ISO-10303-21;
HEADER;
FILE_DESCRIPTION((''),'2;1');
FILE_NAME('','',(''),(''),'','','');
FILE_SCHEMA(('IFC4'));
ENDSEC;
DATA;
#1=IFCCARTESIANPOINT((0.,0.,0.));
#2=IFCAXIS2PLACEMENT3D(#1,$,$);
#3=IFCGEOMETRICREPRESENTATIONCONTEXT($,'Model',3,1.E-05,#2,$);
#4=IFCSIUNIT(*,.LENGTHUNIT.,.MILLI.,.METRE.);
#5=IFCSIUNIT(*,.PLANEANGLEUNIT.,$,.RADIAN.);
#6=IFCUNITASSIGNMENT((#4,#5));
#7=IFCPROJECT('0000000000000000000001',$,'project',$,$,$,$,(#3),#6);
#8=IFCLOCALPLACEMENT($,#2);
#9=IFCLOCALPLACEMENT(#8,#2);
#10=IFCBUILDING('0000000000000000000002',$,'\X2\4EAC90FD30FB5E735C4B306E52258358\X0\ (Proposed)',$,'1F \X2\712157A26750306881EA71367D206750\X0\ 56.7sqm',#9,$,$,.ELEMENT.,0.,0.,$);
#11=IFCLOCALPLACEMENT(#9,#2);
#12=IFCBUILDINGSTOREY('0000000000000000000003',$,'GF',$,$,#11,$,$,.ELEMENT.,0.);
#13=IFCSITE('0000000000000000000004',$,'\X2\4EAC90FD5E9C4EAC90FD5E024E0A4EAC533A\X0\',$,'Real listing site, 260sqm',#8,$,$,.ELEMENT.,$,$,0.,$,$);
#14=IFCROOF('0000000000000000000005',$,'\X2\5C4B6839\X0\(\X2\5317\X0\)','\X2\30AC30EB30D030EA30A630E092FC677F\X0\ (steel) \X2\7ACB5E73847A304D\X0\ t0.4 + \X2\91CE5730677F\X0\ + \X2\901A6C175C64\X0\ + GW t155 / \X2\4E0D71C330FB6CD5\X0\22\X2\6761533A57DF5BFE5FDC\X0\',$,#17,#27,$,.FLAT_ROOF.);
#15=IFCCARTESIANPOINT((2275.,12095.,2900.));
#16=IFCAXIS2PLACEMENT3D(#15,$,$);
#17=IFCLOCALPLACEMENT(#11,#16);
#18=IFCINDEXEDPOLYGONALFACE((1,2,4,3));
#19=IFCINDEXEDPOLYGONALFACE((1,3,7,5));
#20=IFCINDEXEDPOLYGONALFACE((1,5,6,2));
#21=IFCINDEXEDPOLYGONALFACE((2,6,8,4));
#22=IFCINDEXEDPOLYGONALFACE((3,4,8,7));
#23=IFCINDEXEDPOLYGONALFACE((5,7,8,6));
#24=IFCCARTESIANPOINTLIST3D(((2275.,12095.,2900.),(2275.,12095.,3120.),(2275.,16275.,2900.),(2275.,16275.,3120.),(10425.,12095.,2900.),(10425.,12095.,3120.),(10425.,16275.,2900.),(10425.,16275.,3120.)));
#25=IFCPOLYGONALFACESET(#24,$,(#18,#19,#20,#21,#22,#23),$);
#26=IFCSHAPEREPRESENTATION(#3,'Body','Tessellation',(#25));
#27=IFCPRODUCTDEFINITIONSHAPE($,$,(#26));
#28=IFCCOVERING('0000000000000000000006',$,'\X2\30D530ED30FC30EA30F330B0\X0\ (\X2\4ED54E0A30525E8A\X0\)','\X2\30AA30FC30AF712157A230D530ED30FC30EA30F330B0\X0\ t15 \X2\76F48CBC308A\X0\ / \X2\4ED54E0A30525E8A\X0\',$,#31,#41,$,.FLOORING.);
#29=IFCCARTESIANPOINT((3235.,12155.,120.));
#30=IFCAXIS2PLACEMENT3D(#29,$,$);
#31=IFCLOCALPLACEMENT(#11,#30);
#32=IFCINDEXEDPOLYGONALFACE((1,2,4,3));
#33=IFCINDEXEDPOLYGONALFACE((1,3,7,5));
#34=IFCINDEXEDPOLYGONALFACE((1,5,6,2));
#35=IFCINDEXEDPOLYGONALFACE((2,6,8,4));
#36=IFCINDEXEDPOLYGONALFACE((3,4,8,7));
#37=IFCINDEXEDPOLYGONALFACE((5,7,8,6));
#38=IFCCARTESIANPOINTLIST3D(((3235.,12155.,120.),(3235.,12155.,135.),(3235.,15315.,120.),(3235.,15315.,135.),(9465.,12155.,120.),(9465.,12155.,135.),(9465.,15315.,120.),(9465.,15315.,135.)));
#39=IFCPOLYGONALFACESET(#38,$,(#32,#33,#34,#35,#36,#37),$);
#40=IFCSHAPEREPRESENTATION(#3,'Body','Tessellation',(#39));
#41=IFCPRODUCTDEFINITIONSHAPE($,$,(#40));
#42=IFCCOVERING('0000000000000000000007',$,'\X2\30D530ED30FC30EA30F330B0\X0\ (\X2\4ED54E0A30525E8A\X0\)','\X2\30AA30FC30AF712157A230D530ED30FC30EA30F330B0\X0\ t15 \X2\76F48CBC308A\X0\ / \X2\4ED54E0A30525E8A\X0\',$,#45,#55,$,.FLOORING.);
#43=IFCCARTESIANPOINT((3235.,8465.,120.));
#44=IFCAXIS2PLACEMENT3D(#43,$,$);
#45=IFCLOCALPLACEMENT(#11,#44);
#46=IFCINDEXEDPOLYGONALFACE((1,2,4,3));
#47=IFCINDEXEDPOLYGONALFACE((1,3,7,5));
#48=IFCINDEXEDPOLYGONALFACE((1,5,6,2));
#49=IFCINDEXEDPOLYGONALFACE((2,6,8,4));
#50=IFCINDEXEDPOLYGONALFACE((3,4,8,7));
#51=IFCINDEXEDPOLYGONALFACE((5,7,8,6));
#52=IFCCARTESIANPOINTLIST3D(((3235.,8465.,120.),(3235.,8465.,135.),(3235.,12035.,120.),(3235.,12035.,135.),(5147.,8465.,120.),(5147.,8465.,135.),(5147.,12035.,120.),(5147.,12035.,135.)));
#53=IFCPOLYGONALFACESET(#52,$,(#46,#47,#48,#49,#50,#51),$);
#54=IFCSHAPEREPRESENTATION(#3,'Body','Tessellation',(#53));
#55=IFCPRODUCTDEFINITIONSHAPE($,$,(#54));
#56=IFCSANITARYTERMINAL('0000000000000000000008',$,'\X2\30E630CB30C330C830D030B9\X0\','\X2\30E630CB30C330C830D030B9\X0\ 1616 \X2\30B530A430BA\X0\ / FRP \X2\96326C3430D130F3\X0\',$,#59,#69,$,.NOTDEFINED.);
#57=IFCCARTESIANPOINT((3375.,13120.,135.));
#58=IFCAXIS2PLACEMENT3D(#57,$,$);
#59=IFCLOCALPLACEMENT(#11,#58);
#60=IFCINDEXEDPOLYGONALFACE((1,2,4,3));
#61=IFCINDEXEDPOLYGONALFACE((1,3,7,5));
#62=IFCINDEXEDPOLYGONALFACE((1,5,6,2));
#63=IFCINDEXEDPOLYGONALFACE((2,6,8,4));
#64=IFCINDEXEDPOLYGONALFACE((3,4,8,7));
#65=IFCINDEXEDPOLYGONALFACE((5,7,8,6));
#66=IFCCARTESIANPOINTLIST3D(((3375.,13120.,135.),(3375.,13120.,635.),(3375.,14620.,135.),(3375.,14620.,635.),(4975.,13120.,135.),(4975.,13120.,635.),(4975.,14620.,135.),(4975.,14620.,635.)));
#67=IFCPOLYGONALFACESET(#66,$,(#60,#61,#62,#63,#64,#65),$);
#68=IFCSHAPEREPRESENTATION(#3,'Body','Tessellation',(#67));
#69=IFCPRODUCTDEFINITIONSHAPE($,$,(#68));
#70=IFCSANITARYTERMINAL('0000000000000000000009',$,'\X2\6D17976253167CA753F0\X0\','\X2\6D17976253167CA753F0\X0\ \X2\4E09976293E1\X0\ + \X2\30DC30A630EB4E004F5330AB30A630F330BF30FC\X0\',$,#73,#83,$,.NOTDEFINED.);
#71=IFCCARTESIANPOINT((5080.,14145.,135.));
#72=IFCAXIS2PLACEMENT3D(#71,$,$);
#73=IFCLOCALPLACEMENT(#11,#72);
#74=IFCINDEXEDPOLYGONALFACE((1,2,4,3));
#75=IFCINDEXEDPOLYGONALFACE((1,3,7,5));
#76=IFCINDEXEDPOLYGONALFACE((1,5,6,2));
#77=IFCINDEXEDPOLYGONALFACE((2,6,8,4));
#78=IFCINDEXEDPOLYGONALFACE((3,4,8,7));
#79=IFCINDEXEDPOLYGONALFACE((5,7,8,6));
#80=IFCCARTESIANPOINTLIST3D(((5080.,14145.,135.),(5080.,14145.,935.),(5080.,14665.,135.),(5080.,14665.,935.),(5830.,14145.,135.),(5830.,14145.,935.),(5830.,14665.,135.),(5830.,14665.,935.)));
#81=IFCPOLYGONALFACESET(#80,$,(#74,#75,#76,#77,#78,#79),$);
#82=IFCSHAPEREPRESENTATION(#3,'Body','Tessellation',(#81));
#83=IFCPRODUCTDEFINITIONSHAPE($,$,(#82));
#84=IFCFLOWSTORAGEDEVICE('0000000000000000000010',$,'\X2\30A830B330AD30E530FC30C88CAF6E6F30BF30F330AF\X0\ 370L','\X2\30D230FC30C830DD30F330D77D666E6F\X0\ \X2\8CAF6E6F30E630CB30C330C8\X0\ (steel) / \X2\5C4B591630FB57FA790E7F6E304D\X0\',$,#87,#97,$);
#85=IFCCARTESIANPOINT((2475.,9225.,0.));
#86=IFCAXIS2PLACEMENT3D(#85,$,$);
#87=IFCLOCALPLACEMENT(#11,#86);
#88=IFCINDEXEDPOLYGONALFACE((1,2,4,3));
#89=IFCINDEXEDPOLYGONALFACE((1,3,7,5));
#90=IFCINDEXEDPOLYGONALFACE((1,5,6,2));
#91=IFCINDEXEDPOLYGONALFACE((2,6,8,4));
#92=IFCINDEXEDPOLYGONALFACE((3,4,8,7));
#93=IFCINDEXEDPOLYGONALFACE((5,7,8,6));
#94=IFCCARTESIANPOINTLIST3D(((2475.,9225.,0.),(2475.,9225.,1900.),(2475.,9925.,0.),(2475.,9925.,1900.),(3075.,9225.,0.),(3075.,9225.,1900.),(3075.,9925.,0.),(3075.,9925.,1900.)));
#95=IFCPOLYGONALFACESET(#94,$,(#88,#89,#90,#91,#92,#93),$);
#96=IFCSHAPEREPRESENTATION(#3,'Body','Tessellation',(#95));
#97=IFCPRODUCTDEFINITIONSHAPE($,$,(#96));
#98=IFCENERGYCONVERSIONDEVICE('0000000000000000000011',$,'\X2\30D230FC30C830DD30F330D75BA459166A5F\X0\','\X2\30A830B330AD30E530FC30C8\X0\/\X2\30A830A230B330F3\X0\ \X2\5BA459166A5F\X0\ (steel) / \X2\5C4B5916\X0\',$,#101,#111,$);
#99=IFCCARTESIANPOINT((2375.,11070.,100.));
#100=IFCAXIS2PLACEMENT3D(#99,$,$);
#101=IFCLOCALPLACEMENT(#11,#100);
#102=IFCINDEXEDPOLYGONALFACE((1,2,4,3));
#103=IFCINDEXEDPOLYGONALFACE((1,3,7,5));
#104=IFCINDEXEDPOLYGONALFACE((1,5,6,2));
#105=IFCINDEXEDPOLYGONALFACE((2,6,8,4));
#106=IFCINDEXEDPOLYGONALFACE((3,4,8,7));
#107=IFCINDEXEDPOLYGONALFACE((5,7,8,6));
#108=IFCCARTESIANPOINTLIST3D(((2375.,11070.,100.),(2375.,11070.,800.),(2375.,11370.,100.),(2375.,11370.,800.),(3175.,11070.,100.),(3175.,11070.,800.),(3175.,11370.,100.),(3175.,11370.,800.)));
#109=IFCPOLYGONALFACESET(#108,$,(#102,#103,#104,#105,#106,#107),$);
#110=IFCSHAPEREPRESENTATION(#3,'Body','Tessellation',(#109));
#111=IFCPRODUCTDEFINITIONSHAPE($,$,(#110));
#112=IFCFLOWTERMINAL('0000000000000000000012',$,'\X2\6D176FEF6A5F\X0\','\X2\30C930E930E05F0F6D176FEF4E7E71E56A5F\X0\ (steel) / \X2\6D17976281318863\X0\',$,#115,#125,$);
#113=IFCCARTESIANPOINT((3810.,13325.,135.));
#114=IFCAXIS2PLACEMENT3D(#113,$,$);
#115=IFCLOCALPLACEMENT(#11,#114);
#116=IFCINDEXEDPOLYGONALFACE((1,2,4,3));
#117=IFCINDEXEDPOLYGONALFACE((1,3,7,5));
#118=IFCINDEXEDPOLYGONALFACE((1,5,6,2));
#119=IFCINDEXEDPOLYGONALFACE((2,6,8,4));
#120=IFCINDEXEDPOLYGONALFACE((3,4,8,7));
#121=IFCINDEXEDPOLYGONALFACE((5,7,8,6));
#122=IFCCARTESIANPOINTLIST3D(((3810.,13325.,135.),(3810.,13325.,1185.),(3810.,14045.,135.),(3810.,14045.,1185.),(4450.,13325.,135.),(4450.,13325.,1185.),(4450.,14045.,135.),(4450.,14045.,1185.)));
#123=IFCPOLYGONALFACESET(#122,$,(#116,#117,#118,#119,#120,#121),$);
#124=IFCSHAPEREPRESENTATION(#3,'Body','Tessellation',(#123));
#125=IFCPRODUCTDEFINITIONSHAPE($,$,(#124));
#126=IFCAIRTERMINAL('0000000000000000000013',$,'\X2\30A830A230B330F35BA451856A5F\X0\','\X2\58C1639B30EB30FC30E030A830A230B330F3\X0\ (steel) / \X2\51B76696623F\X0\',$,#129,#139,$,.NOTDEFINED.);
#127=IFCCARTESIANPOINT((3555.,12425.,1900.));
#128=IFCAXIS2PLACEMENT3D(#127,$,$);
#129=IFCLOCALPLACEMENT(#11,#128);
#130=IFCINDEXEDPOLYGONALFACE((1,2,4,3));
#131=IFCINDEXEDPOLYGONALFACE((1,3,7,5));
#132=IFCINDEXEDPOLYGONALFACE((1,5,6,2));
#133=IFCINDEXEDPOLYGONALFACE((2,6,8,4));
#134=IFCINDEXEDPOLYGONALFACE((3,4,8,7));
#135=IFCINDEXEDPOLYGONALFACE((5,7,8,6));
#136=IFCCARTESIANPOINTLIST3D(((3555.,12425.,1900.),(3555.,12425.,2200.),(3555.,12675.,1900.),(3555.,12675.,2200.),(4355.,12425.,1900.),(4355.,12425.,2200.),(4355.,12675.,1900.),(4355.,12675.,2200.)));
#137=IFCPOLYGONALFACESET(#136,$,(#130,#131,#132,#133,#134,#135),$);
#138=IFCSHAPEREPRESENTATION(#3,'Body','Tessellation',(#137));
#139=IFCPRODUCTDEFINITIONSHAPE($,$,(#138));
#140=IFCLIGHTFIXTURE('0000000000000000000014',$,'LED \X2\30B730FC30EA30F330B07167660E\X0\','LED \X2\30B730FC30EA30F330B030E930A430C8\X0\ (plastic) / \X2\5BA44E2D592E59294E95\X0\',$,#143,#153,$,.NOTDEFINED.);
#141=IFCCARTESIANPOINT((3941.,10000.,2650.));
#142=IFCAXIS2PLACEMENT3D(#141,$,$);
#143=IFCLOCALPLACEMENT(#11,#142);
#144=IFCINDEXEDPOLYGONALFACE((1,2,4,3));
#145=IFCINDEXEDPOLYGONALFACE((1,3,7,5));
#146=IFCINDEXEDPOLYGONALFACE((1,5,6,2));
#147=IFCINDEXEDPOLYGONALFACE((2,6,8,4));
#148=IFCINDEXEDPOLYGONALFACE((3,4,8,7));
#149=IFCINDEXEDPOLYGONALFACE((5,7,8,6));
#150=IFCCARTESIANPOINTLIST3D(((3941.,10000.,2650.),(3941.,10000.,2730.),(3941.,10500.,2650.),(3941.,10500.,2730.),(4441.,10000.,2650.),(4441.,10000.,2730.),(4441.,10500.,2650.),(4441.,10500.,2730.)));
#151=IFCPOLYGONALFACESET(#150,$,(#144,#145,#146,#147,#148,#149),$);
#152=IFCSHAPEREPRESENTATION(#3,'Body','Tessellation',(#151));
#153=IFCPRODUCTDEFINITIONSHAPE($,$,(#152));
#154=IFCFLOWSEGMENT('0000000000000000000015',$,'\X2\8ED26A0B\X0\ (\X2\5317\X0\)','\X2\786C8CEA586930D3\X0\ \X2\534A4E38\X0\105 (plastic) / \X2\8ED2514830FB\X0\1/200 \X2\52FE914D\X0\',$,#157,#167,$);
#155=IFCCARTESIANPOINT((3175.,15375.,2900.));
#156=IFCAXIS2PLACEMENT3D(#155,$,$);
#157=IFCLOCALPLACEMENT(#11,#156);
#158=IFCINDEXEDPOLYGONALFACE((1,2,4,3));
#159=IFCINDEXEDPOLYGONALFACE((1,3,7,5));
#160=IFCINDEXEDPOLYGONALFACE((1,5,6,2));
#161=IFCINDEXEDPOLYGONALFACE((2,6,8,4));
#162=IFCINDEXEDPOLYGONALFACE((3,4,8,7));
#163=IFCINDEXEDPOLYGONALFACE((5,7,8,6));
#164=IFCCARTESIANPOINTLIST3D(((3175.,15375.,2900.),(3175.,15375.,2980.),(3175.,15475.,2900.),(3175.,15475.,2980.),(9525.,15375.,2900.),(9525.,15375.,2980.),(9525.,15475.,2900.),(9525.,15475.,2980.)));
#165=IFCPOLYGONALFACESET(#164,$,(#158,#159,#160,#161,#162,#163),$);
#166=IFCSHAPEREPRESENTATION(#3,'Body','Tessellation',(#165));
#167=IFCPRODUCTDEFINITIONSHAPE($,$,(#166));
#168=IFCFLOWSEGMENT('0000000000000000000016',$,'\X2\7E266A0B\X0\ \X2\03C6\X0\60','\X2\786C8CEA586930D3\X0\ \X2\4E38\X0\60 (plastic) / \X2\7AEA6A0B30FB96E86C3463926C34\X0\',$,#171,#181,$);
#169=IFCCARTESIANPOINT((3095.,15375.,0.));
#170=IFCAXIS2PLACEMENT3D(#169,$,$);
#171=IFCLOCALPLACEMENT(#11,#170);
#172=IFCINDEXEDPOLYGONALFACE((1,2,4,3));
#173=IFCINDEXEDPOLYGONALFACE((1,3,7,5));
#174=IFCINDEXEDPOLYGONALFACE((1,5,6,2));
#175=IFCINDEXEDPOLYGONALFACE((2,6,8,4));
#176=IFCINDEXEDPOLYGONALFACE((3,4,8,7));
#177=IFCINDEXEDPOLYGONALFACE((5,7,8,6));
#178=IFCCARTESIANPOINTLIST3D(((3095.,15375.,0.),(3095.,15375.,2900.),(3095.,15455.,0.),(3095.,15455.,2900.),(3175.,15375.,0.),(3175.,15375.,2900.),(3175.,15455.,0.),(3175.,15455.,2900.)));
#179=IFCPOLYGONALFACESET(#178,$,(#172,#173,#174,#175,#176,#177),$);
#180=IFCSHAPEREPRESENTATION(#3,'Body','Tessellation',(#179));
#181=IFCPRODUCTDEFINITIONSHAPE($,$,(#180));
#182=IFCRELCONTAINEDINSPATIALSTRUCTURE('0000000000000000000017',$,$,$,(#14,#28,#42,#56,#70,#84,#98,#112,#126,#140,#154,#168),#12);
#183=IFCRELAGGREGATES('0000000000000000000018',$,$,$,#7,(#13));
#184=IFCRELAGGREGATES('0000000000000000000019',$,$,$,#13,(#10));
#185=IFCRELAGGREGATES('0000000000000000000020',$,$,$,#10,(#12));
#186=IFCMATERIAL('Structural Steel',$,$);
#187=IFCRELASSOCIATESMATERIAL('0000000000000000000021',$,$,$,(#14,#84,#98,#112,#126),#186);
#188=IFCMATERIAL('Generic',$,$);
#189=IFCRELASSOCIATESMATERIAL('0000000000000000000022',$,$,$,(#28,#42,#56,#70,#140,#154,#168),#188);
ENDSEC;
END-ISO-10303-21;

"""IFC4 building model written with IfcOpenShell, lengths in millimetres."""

from ifc_helpers import new_model, si_unit, frame, frame_2d, origin, place, context, project, spatial, rectangle, extrude, material, element, save


model = new_model("IFC4")

# Units and contexts
model_context = context("Model", 3, precision=1e-05, world=origin())
ifc_project = project(units=[si_unit("LENGTHUNIT", "METRE", prefix="MILLI"), si_unit("PLANEANGLEUNIT", "RADIAN")], contexts=[model_context])

# Site, building, storey
site_placement = place(None, origin())
site = spatial("IfcSite", under=ifc_project, at=site_placement, Name="京都府京都市上京区", ObjectType="Real listing site, 260sqm", CompositionType="ELEMENT", RefElevation=0.0)
building_placement = place(site_placement, origin())
building = spatial("IfcBuilding", under=site, at=building_placement, Name="京都・平屋の別荘 (Proposed)", ObjectType="1F 無垢材と自然素材 56.7sqm", CompositionType="ELEMENT", ElevationOfRefHeight=0.0, ElevationOfTerrain=0.0)
storey_placement = place(building_placement, origin())
storey = spatial("IfcBuildingStorey", under=building, at=storey_placement, Name="GF", CompositionType="ELEMENT", Elevation=0.0)

# Roof
ifc_material_1 = material(Name="Structural Steel")
roof_placement = place(storey_placement, frame((2275.0, 12095.0, 2900.0)))
element("IfcRoof", 1, at=roof_placement, inside=storey, material=ifc_material_1, Name="屋根(北)", Description="ガルバリウム鋼板 (steel) 立平葺き t0.4 + 野地板 + 通気層 + GW t155 / 不燃・法22条区域対応", PredefinedType="FLAT_ROOF", context=model_context, shape_type="SweptSolid", body=[
    extrude(rectangle(XDim=8150.0, YDim=4180.0, at=frame_2d((4075.0, 2090.0))), frame((2275.0, 12095.0, 2900.0)), (0.0, 0.0, 1.0), 220.0),
])

# Coverings
ifc_material_2 = material(Name="Generic")
covering_1_placement = place(storey_placement, frame((3235.0, 12155.0, 120.0)))
element("IfcCovering", 2, at=covering_1_placement, inside=storey, material=ifc_material_2, Name="フローリング (仕上げ床)", Description="オーク無垢フローリング t15 直貼り / 仕上げ床", PredefinedType="FLOORING", context=model_context, shape_type="SweptSolid", body=[
    extrude(rectangle(XDim=6230.0, YDim=3160.0, at=frame_2d((3115.0, 1580.0))), frame((3235.0, 12155.0, 120.0)), (0.0, 0.0, 1.0), 15.0),
])
covering_2_placement = place(storey_placement, frame((3235.0, 8465.0, 120.0)))
element("IfcCovering", 3, at=covering_2_placement, inside=storey, material=ifc_material_2, Name="フローリング (仕上げ床)", Description="オーク無垢フローリング t15 直貼り / 仕上げ床", PredefinedType="FLOORING", context=model_context, shape_type="SweptSolid", body=[
    extrude(rectangle(XDim=1912.0, YDim=3570.0, at=frame_2d((956.0, 1785.0))), frame((3235.0, 8465.0, 120.0)), (0.0, 0.0, 1.0), 15.0),
])

# Sanitary terminals
sanitary_terminal_1_placement = place(storey_placement, frame((3375.0, 13120.0, 135.0)))
element("IfcSanitaryTerminal", 4, at=sanitary_terminal_1_placement, inside=storey, material=ifc_material_2, Name="ユニットバス", Description="ユニットバス 1616 サイズ / FRP 防水パン", PredefinedType="NOTDEFINED", context=model_context, shape_type="SweptSolid", body=[
    extrude(rectangle(XDim=1600.0, YDim=1500.0, at=frame_2d((800.0, 750.0))), frame((3375.0, 13120.0, 135.0)), (0.0, 0.0, 1.0), 500.0),
])
sanitary_terminal_2_placement = place(storey_placement, frame((5080.0, 14145.0, 135.0)))
element("IfcSanitaryTerminal", 5, at=sanitary_terminal_2_placement, inside=storey, material=ifc_material_2, Name="洗面化粧台", Description="洗面化粧台 三面鏡 + ボウル一体カウンター", PredefinedType="NOTDEFINED", context=model_context, shape_type="SweptSolid", body=[
    extrude(rectangle(XDim=750.0, YDim=520.0, at=frame_2d((375.0, 260.0))), frame((5080.0, 14145.0, 135.0)), (0.0, 0.0, 1.0), 800.0),
])

# Flow storage device
flow_storage_device_placement = place(storey_placement, frame((2475.0, 9225.0, 0.0)))
element("IfcFlowStorageDevice", 6, at=flow_storage_device_placement, inside=storey, material=ifc_material_1, Name="エコキュート貯湯タンク 370L", Description="ヒートポンプ給湯 貯湯ユニット (steel) / 屋外・基礎置き", context=model_context, shape_type="SweptSolid", body=[
    extrude(rectangle(XDim=600.0, YDim=700.0, at=frame_2d((300.0, 350.0))), frame((2475.0, 9225.0, 0.0)), (0.0, 0.0, 1.0), 1900.0),
])

# Energy conversion device
energy_conversion_device_placement = place(storey_placement, frame((2375.0, 11070.0, 100.0)))
element("IfcEnergyConversionDevice", 7, at=energy_conversion_device_placement, inside=storey, material=ifc_material_1, Name="ヒートポンプ室外機", Description="エコキュート/エアコン 室外機 (steel) / 屋外", context=model_context, shape_type="SweptSolid", body=[
    extrude(rectangle(XDim=800.0, YDim=300.0, at=frame_2d((400.0, 150.0))), frame((2375.0, 11070.0, 100.0)), (0.0, 0.0, 1.0), 700.0),
])

# Flow terminal
flow_terminal_placement = place(storey_placement, frame((3810.0, 13325.0, 135.0)))
element("IfcFlowTerminal", 8, at=flow_terminal_placement, inside=storey, material=ifc_material_1, Name="洗濯機", Description="ドラム式洗濯乾燥機 (steel) / 洗面脱衣", context=model_context, shape_type="SweptSolid", body=[
    extrude(rectangle(XDim=640.0, YDim=720.0, at=frame_2d((320.0, 360.0))), frame((3810.0, 13325.0, 135.0)), (0.0, 0.0, 1.0), 1050.0),
])

# Air terminal
air_terminal_placement = place(storey_placement, frame((3555.0, 12425.0, 1900.0)))
element("IfcAirTerminal", 9, at=air_terminal_placement, inside=storey, material=ifc_material_1, Name="エアコン室内機", Description="壁掛ルームエアコン (steel) / 冷暖房", PredefinedType="NOTDEFINED", context=model_context, shape_type="SweptSolid", body=[
    extrude(rectangle(XDim=800.0, YDim=250.0, at=frame_2d((400.0, 125.0))), frame((3555.0, 12425.0, 1900.0)), (0.0, 0.0, 1.0), 300.0),
])

# Light fixture
light_fixture_placement = place(storey_placement, frame((3941.0, 10000.0, 2650.0)))
element("IfcLightFixture", 10, at=light_fixture_placement, inside=storey, material=ifc_material_2, Name="LED シーリング照明", Description="LED シーリングライト (plastic) / 室中央天井", PredefinedType="NOTDEFINED", context=model_context, shape_type="SweptSolid", body=[
    extrude(rectangle(XDim=500.0, YDim=500.0, at=frame_2d((250.0, 250.0))), frame((3941.0, 10000.0, 2650.0)), (0.0, 0.0, 1.0), 80.0),
])

# Flow segments
flow_segment_1_placement = place(storey_placement, frame((3175.0, 15375.0, 2900.0)))
element("IfcFlowSegment", 11, at=flow_segment_1_placement, inside=storey, material=ifc_material_2, Name="軒樋 (北)", Description="硬質塩ビ 半丸105 (plastic) / 軒先・1/200 勾配", context=model_context, shape_type="SweptSolid", body=[
    extrude(rectangle(XDim=6350.0, YDim=100.0, at=frame_2d((3175.0, 50.0))), frame((3175.0, 15375.0, 2900.0)), (0.0, 0.0, 1.0), 80.0),
])
flow_segment_2_placement = place(storey_placement, frame((3095.0, 15375.0, 0.0)))
element("IfcFlowSegment", 12, at=flow_segment_2_placement, inside=storey, material=ifc_material_2, Name="縦樋 φ60", Description="硬質塩ビ 丸60 (plastic) / 竪樋・雨水排水", context=model_context, shape_type="SweptSolid", body=[
    extrude(rectangle(XDim=80.0, YDim=80.0, at=frame_2d((40.0, 40.0))), frame((3095.0, 15375.0, 0.0)), (0.0, 0.0, 1.0), 2900.0),
])

save(model, "model.ifc")
